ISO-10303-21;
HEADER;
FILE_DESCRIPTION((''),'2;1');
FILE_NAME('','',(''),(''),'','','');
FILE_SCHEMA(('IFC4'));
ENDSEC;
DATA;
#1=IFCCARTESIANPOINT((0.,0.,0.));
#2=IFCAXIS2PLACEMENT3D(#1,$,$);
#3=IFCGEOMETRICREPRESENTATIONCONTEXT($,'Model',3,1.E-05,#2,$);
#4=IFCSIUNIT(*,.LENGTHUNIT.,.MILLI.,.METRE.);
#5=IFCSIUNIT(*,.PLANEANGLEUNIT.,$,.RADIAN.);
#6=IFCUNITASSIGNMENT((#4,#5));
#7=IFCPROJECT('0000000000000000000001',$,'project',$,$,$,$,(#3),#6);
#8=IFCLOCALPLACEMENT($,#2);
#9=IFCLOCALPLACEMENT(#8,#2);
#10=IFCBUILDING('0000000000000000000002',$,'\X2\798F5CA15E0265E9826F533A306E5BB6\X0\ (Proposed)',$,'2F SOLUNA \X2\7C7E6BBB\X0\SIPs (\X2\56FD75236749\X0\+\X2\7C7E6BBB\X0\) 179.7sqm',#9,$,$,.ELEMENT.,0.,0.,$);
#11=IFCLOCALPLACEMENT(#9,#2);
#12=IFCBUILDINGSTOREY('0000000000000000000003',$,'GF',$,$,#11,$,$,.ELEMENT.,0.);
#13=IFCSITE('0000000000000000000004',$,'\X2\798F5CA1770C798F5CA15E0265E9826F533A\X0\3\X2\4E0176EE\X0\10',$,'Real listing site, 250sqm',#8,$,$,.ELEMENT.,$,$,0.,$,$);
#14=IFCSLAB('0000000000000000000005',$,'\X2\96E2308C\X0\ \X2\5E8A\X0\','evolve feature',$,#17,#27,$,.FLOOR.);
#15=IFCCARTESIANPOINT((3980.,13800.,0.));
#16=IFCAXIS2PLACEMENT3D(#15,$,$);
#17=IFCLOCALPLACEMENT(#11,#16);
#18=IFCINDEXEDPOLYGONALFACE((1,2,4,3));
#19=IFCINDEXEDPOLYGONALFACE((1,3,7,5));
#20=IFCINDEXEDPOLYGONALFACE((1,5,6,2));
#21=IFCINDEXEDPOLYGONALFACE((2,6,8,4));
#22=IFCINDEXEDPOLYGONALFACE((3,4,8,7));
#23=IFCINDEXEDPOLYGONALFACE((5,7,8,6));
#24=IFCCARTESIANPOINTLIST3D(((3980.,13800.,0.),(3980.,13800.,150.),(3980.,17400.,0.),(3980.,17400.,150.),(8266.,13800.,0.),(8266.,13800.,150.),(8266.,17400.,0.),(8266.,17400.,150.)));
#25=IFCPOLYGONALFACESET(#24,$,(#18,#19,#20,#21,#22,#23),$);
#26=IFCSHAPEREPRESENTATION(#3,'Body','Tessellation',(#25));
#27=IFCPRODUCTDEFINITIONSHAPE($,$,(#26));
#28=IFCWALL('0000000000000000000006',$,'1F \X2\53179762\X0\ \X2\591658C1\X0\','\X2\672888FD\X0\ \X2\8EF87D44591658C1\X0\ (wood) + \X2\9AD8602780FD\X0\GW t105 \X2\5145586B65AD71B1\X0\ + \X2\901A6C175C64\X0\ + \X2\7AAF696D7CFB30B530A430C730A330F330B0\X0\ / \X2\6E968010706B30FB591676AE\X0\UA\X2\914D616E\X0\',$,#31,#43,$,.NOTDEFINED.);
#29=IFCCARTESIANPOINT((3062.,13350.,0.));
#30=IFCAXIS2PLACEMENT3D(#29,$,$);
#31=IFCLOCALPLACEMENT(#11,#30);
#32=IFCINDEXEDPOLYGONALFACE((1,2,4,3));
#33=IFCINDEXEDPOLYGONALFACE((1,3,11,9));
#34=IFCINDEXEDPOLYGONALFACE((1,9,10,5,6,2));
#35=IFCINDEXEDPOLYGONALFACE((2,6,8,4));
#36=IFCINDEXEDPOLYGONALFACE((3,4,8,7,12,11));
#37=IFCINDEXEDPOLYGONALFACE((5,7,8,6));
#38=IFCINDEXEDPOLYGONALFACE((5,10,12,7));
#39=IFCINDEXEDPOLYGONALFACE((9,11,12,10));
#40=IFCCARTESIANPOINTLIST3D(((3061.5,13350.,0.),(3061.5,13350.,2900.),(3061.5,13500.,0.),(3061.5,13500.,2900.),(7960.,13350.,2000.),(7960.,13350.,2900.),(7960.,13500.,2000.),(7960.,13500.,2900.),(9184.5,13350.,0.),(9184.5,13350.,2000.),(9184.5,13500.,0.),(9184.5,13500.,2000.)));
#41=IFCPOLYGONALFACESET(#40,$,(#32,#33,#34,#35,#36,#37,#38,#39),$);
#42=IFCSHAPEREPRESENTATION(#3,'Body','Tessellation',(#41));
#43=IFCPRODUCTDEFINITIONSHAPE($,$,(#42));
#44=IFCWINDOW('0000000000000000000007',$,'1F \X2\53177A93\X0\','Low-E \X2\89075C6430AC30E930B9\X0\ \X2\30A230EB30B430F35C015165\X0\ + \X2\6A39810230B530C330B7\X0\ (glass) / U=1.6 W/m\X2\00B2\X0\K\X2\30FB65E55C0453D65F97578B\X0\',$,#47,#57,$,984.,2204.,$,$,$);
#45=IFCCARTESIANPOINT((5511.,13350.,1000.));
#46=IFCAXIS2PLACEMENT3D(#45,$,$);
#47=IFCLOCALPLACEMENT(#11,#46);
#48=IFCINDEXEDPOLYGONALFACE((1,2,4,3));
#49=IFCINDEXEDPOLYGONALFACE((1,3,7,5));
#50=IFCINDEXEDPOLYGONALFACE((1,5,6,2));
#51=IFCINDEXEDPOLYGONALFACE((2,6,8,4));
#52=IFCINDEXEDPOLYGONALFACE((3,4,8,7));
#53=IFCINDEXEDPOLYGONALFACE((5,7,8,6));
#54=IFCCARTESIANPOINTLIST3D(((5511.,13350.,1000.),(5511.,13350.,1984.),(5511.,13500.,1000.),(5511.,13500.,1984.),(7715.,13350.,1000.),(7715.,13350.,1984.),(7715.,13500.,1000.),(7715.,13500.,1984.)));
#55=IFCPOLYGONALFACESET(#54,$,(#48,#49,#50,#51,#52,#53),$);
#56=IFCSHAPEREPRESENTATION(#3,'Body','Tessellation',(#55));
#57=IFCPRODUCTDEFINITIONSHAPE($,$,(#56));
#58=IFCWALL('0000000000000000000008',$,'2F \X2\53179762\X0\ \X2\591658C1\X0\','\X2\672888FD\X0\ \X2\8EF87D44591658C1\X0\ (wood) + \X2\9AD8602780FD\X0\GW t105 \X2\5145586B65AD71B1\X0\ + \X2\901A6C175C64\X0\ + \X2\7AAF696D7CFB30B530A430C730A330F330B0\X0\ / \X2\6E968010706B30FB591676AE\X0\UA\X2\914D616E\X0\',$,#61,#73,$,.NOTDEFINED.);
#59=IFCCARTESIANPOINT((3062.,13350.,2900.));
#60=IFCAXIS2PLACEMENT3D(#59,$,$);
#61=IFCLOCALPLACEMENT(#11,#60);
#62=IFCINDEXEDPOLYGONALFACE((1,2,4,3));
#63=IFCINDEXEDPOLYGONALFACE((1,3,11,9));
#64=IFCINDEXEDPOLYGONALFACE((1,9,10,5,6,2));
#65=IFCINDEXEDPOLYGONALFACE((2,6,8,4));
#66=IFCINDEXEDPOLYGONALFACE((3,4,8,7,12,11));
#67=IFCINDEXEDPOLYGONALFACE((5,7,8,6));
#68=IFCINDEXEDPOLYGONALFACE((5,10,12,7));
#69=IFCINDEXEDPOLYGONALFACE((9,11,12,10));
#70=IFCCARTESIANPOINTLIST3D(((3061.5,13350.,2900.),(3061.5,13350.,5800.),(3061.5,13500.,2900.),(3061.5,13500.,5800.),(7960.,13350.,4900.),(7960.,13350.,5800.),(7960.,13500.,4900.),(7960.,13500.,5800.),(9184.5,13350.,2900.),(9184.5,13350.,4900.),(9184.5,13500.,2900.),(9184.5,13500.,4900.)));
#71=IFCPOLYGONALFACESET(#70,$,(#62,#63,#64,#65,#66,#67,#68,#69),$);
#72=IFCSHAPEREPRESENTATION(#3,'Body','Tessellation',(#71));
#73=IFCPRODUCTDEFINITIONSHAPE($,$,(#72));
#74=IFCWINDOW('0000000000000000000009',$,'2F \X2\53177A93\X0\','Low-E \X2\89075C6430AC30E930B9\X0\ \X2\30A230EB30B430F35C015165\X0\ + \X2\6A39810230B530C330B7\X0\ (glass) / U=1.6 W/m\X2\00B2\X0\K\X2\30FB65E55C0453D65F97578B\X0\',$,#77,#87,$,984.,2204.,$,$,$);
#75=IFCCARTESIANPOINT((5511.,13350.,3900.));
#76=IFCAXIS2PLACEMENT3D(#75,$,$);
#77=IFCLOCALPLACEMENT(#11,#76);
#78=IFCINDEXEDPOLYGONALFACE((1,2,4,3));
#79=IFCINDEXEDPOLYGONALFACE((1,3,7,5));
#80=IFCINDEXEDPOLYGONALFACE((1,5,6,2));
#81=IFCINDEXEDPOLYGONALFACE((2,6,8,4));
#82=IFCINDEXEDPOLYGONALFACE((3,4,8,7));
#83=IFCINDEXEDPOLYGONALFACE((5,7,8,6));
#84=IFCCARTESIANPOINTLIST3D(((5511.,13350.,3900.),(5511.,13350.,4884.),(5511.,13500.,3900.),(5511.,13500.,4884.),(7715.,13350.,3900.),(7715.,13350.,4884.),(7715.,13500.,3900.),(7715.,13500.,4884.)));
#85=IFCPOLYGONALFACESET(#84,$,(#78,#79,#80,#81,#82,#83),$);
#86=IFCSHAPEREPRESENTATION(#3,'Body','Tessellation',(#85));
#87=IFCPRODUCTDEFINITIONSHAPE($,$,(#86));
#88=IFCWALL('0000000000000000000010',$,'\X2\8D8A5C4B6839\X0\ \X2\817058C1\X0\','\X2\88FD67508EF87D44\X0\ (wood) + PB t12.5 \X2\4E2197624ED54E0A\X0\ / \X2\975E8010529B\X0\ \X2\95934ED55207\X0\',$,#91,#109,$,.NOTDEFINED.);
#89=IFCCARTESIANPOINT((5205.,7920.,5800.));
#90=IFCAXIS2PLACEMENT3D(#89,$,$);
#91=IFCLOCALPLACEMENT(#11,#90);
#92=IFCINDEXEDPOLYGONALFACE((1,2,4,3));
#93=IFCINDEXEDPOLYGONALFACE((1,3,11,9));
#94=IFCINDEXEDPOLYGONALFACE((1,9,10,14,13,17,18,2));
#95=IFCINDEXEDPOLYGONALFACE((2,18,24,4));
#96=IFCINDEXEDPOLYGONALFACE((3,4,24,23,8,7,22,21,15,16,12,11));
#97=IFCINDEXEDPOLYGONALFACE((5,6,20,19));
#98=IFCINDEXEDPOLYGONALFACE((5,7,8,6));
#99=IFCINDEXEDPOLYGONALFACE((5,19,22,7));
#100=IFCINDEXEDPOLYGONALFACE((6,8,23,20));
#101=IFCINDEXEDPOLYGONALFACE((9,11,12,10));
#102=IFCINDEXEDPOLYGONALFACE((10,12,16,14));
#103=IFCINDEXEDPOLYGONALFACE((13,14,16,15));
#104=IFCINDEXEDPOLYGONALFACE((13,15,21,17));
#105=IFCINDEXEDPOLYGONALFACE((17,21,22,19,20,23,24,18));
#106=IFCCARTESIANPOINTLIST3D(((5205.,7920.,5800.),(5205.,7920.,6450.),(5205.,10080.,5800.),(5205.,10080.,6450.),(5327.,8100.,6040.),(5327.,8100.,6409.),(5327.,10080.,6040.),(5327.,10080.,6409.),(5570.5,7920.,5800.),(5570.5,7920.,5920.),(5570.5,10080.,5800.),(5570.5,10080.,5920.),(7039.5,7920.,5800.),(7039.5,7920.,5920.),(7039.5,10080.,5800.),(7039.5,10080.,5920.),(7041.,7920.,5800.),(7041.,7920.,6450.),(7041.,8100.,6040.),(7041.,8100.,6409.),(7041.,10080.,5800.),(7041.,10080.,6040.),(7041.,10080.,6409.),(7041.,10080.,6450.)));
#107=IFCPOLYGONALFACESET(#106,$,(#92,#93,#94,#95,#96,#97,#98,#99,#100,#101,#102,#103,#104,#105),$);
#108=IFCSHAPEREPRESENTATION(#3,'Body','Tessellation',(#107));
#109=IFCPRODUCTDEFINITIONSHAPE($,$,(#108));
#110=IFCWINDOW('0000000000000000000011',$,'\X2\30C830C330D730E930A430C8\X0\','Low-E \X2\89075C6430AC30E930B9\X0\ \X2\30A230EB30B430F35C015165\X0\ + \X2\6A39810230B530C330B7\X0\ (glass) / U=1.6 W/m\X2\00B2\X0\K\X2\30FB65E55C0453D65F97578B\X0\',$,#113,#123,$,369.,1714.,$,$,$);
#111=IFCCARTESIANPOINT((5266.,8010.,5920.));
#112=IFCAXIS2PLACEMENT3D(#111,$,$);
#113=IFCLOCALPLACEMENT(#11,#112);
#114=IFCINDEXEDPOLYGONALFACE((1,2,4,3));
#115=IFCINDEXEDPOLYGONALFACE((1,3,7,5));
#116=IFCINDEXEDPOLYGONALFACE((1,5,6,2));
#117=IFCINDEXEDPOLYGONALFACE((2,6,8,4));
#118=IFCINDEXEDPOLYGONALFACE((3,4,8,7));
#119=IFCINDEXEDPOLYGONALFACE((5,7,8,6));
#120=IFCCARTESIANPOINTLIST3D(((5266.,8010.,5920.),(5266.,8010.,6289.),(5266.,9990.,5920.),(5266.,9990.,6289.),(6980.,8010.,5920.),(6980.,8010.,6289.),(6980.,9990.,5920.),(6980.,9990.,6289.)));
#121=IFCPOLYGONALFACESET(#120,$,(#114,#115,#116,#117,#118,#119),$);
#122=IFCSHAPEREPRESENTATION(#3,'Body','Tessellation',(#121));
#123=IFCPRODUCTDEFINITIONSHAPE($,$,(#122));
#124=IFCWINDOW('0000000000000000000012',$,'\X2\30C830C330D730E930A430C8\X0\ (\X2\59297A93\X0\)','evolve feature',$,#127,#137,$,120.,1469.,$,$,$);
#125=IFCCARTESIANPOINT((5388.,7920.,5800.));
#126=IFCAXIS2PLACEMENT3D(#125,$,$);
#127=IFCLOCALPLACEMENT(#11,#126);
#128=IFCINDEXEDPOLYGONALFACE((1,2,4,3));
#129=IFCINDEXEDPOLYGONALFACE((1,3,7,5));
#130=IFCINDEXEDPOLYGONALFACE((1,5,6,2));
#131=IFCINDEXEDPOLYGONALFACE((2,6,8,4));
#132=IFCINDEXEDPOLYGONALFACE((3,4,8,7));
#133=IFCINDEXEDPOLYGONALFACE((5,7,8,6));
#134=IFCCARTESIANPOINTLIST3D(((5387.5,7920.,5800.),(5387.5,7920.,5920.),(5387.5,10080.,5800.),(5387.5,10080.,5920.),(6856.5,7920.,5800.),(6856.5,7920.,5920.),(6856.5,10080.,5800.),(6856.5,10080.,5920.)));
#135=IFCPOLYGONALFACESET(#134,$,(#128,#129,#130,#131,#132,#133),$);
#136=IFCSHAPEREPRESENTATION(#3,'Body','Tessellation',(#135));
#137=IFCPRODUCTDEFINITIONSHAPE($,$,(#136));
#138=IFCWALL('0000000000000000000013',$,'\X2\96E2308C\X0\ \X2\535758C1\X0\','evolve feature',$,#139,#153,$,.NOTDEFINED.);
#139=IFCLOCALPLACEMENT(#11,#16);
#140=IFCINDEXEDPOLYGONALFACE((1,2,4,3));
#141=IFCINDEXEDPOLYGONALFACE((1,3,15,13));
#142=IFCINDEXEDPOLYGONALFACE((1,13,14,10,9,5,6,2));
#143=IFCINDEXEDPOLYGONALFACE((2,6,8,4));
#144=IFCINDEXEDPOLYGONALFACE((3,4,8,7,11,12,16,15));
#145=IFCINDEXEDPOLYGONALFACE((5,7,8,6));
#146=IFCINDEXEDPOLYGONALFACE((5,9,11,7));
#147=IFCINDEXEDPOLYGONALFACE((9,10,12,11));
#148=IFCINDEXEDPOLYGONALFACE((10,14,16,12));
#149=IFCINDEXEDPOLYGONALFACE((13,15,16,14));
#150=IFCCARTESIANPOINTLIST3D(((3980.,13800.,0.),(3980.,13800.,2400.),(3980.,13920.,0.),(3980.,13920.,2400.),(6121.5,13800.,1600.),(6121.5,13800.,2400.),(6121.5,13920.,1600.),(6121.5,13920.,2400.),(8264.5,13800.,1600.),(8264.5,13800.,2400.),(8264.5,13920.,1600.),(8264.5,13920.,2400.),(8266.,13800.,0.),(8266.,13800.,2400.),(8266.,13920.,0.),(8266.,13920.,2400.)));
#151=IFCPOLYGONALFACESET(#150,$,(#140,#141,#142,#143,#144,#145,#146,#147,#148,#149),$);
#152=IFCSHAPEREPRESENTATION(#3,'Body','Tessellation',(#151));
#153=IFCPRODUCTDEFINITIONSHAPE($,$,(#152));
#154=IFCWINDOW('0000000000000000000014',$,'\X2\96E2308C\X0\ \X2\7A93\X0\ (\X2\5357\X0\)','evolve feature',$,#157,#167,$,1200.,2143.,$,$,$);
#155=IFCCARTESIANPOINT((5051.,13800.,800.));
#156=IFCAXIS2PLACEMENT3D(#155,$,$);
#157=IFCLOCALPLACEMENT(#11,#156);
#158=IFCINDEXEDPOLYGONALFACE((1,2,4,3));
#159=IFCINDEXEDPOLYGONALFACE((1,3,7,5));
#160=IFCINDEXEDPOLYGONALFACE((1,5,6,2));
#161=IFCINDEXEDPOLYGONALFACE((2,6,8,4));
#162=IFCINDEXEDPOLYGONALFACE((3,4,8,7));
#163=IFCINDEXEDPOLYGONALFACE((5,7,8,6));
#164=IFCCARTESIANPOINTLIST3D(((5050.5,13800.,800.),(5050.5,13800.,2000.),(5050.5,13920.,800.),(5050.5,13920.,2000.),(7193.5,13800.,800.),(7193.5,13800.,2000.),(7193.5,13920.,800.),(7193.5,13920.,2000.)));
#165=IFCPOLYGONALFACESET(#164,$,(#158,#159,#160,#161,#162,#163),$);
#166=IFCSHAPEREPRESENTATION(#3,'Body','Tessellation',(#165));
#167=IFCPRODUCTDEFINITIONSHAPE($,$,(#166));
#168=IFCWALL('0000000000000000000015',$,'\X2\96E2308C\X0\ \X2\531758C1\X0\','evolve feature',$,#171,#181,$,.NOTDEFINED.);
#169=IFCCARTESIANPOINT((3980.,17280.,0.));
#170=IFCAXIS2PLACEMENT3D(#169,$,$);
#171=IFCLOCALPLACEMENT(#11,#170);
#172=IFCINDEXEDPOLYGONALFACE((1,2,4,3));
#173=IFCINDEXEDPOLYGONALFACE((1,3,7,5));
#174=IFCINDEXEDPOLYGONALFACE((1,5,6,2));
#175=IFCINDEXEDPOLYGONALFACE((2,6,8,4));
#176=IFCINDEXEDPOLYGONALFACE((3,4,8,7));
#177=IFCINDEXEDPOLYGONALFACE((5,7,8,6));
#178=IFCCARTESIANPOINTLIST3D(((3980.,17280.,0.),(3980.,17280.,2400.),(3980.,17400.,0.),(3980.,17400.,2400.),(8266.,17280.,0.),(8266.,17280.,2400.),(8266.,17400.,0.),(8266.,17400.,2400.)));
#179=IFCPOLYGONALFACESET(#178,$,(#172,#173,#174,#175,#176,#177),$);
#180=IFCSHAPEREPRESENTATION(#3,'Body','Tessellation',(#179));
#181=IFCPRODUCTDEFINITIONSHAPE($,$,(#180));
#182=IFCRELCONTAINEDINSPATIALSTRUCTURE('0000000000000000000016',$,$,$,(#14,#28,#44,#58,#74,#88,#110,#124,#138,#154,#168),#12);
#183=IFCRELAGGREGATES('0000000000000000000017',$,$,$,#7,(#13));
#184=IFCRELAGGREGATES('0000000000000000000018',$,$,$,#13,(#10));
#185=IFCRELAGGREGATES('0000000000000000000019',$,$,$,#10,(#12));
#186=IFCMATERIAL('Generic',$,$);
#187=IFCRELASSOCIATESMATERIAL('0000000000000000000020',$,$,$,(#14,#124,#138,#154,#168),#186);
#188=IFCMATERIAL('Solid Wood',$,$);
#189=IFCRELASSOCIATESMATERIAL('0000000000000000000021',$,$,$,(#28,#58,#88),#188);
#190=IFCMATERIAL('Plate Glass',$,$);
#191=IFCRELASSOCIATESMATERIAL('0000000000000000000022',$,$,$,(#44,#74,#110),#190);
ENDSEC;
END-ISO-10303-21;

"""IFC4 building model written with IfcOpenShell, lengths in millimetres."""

from ifc_helpers import new_model, si_unit, frame, frame_2d, origin, place, context, project, spatial, rectangle, extrude, material, element, fill, save


model = new_model("IFC4")

# Units and contexts
model_context = context("Model", 3, precision=1e-05, world=origin())
ifc_project = project(units=[si_unit("LENGTHUNIT", "METRE", prefix="MILLI"), si_unit("PLANEANGLEUNIT", "RADIAN")], contexts=[model_context])

# Site, building, storey
site_placement = place(None, origin())
site = spatial("IfcSite", under=ifc_project, at=site_placement, Name="福岡県福岡市早良区3丁目10", ObjectType="Real listing site, 250sqm", CompositionType="ELEMENT", RefElevation=0.0)
building_placement = place(site_placement, origin())
building = spatial("IfcBuilding", under=site, at=building_placement, Name="福岡市早良区の家 (Proposed)", ObjectType="2F SOLUNA 籾殻SIPs (国産杉+籾殻) 179.7sqm", CompositionType="ELEMENT", ElevationOfRefHeight=0.0, ElevationOfTerrain=0.0)
storey_placement = place(building_placement, origin())
storey = spatial("IfcBuildingStorey", under=building, at=storey_placement, Name="GF", CompositionType="ELEMENT", Elevation=0.0)

# Slab
ifc_material_1 = material(Name="Generic")
slab_placement = place(storey_placement, frame((3980.0, 13800.0, 0.0)))
element("IfcSlab", 1, at=slab_placement, inside=storey, material=ifc_material_1, Name="離れ 床", Description="evolve feature", PredefinedType="FLOOR", context=model_context, shape_type="SweptSolid", body=[
    extrude(rectangle(XDim=4286.0, YDim=3600.0, at=frame_2d((2143.0, 1800.0))), frame((3980.0, 13800.0, 0.0)), (0.0, 0.0, 1.0), 150.0),
])

# Wall, opening, window
ifc_material_2 = material(Name="Solid Wood")
wall_1_placement = place(storey_placement, frame((3062.0, 13350.0, 0.0)))
wall_1 = element("IfcWall", 2, at=wall_1_placement, inside=storey, material=ifc_material_2, Name="1F 北面 外壁", Description="木製 軸組外壁 (wood) + 高性能GW t105 充填断熱 + 通気層 + 窯業系サイディング / 準耐火・外皮UA配慮", PredefinedType="NOTDEFINED", context=model_context, shape_type="SweptSolid", body=[
    extrude(rectangle(XDim=6123.0, YDim=150.0, at=frame_2d((3061.0, 75.0))), frame((3062.0, 13350.0, 0.0)), (0.0, 0.0, 1.0), 2900.0),
])
opening_1_placement = place(storey_placement, frame((5511.0, 13350.0, 1000.0)))
opening_1 = element("IfcOpeningElement", 3, at=opening_1_placement, cuts=wall_1, PredefinedType="NOTDEFINED", context=model_context, shape_type="SweptSolid", body=[
    extrude(rectangle(XDim=2204.0, YDim=150.0, at=frame_2d((1102.0, 75.0))), frame((5511.0, 13350.0, 1000.0)), (0.0, 0.0, 1.0), 984.0),
])
ifc_material_3 = material(Name="Plate Glass")
window_1_placement = place(storey_placement, frame((5511.0, 13350.0, 1000.0)))
window_1 = element("IfcWindow", 4, at=window_1_placement, inside=storey, material=ifc_material_3, Name="1F 北窓", Description="Low-E 複層ガラス アルゴン封入 + 樹脂サッシ (glass) / U=1.6 W/m²K・日射取得型", OverallHeight=984.0, OverallWidth=2204.0, context=model_context, shape_type="SweptSolid", body=[
    extrude(rectangle(XDim=2204.0, YDim=150.0, at=frame_2d((1102.0, 75.0))), frame((5511.0, 13350.0, 1000.0)), (0.0, 0.0, 1.0), 984.0),
])
fill(opening_1, window_1)

# Wall, opening, window
wall_2_placement = place(storey_placement, frame((3062.0, 13350.0, 2900.0)))
wall_2 = element("IfcWall", 5, at=wall_2_placement, inside=storey, material=ifc_material_2, Name="2F 北面 外壁", Description="木製 軸組外壁 (wood) + 高性能GW t105 充填断熱 + 通気層 + 窯業系サイディング / 準耐火・外皮UA配慮", PredefinedType="NOTDEFINED", context=model_context, shape_type="SweptSolid", body=[
    extrude(rectangle(XDim=6123.0, YDim=150.0, at=frame_2d((3061.0, 75.0))), frame((3062.0, 13350.0, 2900.0)), (0.0, 0.0, 1.0), 2900.0),
])
opening_2_placement = place(storey_placement, frame((5511.0, 13350.0, 3900.0)))
opening_2 = element("IfcOpeningElement", 6, at=opening_2_placement, cuts=wall_2, PredefinedType="NOTDEFINED", context=model_context, shape_type="SweptSolid", body=[
    extrude(rectangle(XDim=2204.0, YDim=150.0, at=frame_2d((1102.0, 75.0))), frame((5511.0, 13350.0, 3900.0)), (0.0, 0.0, 1.0), 984.0),
])
window_2_placement = place(storey_placement, frame((5511.0, 13350.0, 3900.0)))
window_2 = element("IfcWindow", 7, at=window_2_placement, inside=storey, material=ifc_material_3, Name="2F 北窓", Description="Low-E 複層ガラス アルゴン封入 + 樹脂サッシ (glass) / U=1.6 W/m²K・日射取得型", OverallHeight=984.0, OverallWidth=2204.0, context=model_context, shape_type="SweptSolid", body=[
    extrude(rectangle(XDim=2204.0, YDim=150.0, at=frame_2d((1102.0, 75.0))), frame((5511.0, 13350.0, 3900.0)), (0.0, 0.0, 1.0), 984.0),
])
fill(opening_2, window_2)

# Wall, openings, windows
wall_3_placement = place(storey_placement, frame((5205.0, 7920.0, 5800.0)))
wall_3 = element("IfcWall", 8, at=wall_3_placement, inside=storey, material=ifc_material_2, Name="越屋根 腰壁", Description="製材軸組 (wood) + PB t12.5 両面仕上 / 非耐力 間仕切", PredefinedType="NOTDEFINED", context=model_context, shape_type="SweptSolid", body=[
    extrude(rectangle(XDim=1836.0, YDim=2160.0, at=frame_2d((918.0, 1080.0))), frame((5205.0, 7920.0, 5800.0)), (0.0, 0.0, 1.0), 650.0),
])
opening_3_placement = place(storey_placement, frame((5266.0, 8010.0, 5920.0)))
opening_3 = element("IfcOpeningElement", 9, at=opening_3_placement, cuts=wall_3, PredefinedType="NOTDEFINED", context=model_context, shape_type="SweptSolid", body=[
    extrude(rectangle(XDim=1714.0, YDim=1980.0, at=frame_2d((857.0, 990.0))), frame((5266.0, 8010.0, 5920.0)), (0.0, 0.0, 1.0), 369.0),
])
opening_4_placement = place(storey_placement, frame((5388.0, 7920.0, 5800.0)))
opening_4 = element("IfcOpeningElement", 10, at=opening_4_placement, cuts=wall_3, PredefinedType="NOTDEFINED", context=model_context, shape_type="SweptSolid", body=[
    extrude(rectangle(XDim=1469.0, YDim=2160.0, at=frame_2d((734.0, 1080.0))), frame((5388.0, 7920.0, 5800.0)), (0.0, 0.0, 1.0), 120.0),
])
window_3_placement = place(storey_placement, frame((5266.0, 8010.0, 5920.0)))
window_3 = element("IfcWindow", 11, at=window_3_placement, inside=storey, material=ifc_material_3, Name="トップライト", Description="Low-E 複層ガラス アルゴン封入 + 樹脂サッシ (glass) / U=1.6 W/m²K・日射取得型", OverallHeight=369.0, OverallWidth=1714.0, context=model_context, shape_type="SweptSolid", body=[
    extrude(rectangle(XDim=1714.0, YDim=1980.0, at=frame_2d((857.0, 990.0))), frame((5266.0, 8010.0, 5920.0)), (0.0, 0.0, 1.0), 369.0),
])
fill(opening_3, window_3)
window_4_placement = place(storey_placement, frame((5388.0, 7920.0, 5800.0)))
window_4 = element("IfcWindow", 12, at=window_4_placement, inside=storey, material=ifc_material_1, Name="トップライト (天窓)", Description="evolve feature", OverallHeight=120.0, OverallWidth=1469.0, context=model_context, shape_type="SweptSolid", body=[
    extrude(rectangle(XDim=1469.0, YDim=2160.0, at=frame_2d((734.0, 1080.0))), frame((5388.0, 7920.0, 5800.0)), (0.0, 0.0, 1.0), 120.0),
])
fill(opening_4, window_4)

# Wall, opening, window
wall_4_placement = place(storey_placement, frame((3980.0, 13800.0, 0.0)))
wall_4 = element("IfcWall", 13, at=wall_4_placement, inside=storey, material=ifc_material_1, Name="離れ 南壁", Description="evolve feature", PredefinedType="NOTDEFINED", context=model_context, shape_type="SweptSolid", body=[
    extrude(rectangle(XDim=4286.0, YDim=120.0, at=frame_2d((2143.0, 60.0))), frame((3980.0, 13800.0, 0.0)), (0.0, 0.0, 1.0), 2400.0),
])
opening_5_placement = place(storey_placement, frame((5051.0, 13800.0, 800.0)))
opening_5 = element("IfcOpeningElement", 14, at=opening_5_placement, cuts=wall_4, PredefinedType="NOTDEFINED", context=model_context, shape_type="SweptSolid", body=[
    extrude(rectangle(XDim=2143.0, YDim=120.0, at=frame_2d((1071.0, 60.0))), frame((5051.0, 13800.0, 800.0)), (0.0, 0.0, 1.0), 1200.0),
])
window_5_placement = place(storey_placement, frame((5051.0, 13800.0, 800.0)))
window_5 = element("IfcWindow", 15, at=window_5_placement, inside=storey, material=ifc_material_1, Name="離れ 窓 (南)", Description="evolve feature", OverallHeight=1200.0, OverallWidth=2143.0, context=model_context, shape_type="SweptSolid", body=[
    extrude(rectangle(XDim=2143.0, YDim=120.0, at=frame_2d((1071.0, 60.0))), frame((5051.0, 13800.0, 800.0)), (0.0, 0.0, 1.0), 1200.0),
])
fill(opening_5, window_5)

# Wall
wall_5_placement = place(storey_placement, frame((3980.0, 17280.0, 0.0)))
element("IfcWall", 16, at=wall_5_placement, inside=storey, material=ifc_material_1, Name="離れ 北壁", Description="evolve feature", PredefinedType="NOTDEFINED", context=model_context, shape_type="SweptSolid", body=[
    extrude(rectangle(XDim=4286.0, YDim=120.0, at=frame_2d((2143.0, 60.0))), frame((3980.0, 17280.0, 0.0)), (0.0, 0.0, 1.0), 2400.0),
])

save(model, "model.ifc")
